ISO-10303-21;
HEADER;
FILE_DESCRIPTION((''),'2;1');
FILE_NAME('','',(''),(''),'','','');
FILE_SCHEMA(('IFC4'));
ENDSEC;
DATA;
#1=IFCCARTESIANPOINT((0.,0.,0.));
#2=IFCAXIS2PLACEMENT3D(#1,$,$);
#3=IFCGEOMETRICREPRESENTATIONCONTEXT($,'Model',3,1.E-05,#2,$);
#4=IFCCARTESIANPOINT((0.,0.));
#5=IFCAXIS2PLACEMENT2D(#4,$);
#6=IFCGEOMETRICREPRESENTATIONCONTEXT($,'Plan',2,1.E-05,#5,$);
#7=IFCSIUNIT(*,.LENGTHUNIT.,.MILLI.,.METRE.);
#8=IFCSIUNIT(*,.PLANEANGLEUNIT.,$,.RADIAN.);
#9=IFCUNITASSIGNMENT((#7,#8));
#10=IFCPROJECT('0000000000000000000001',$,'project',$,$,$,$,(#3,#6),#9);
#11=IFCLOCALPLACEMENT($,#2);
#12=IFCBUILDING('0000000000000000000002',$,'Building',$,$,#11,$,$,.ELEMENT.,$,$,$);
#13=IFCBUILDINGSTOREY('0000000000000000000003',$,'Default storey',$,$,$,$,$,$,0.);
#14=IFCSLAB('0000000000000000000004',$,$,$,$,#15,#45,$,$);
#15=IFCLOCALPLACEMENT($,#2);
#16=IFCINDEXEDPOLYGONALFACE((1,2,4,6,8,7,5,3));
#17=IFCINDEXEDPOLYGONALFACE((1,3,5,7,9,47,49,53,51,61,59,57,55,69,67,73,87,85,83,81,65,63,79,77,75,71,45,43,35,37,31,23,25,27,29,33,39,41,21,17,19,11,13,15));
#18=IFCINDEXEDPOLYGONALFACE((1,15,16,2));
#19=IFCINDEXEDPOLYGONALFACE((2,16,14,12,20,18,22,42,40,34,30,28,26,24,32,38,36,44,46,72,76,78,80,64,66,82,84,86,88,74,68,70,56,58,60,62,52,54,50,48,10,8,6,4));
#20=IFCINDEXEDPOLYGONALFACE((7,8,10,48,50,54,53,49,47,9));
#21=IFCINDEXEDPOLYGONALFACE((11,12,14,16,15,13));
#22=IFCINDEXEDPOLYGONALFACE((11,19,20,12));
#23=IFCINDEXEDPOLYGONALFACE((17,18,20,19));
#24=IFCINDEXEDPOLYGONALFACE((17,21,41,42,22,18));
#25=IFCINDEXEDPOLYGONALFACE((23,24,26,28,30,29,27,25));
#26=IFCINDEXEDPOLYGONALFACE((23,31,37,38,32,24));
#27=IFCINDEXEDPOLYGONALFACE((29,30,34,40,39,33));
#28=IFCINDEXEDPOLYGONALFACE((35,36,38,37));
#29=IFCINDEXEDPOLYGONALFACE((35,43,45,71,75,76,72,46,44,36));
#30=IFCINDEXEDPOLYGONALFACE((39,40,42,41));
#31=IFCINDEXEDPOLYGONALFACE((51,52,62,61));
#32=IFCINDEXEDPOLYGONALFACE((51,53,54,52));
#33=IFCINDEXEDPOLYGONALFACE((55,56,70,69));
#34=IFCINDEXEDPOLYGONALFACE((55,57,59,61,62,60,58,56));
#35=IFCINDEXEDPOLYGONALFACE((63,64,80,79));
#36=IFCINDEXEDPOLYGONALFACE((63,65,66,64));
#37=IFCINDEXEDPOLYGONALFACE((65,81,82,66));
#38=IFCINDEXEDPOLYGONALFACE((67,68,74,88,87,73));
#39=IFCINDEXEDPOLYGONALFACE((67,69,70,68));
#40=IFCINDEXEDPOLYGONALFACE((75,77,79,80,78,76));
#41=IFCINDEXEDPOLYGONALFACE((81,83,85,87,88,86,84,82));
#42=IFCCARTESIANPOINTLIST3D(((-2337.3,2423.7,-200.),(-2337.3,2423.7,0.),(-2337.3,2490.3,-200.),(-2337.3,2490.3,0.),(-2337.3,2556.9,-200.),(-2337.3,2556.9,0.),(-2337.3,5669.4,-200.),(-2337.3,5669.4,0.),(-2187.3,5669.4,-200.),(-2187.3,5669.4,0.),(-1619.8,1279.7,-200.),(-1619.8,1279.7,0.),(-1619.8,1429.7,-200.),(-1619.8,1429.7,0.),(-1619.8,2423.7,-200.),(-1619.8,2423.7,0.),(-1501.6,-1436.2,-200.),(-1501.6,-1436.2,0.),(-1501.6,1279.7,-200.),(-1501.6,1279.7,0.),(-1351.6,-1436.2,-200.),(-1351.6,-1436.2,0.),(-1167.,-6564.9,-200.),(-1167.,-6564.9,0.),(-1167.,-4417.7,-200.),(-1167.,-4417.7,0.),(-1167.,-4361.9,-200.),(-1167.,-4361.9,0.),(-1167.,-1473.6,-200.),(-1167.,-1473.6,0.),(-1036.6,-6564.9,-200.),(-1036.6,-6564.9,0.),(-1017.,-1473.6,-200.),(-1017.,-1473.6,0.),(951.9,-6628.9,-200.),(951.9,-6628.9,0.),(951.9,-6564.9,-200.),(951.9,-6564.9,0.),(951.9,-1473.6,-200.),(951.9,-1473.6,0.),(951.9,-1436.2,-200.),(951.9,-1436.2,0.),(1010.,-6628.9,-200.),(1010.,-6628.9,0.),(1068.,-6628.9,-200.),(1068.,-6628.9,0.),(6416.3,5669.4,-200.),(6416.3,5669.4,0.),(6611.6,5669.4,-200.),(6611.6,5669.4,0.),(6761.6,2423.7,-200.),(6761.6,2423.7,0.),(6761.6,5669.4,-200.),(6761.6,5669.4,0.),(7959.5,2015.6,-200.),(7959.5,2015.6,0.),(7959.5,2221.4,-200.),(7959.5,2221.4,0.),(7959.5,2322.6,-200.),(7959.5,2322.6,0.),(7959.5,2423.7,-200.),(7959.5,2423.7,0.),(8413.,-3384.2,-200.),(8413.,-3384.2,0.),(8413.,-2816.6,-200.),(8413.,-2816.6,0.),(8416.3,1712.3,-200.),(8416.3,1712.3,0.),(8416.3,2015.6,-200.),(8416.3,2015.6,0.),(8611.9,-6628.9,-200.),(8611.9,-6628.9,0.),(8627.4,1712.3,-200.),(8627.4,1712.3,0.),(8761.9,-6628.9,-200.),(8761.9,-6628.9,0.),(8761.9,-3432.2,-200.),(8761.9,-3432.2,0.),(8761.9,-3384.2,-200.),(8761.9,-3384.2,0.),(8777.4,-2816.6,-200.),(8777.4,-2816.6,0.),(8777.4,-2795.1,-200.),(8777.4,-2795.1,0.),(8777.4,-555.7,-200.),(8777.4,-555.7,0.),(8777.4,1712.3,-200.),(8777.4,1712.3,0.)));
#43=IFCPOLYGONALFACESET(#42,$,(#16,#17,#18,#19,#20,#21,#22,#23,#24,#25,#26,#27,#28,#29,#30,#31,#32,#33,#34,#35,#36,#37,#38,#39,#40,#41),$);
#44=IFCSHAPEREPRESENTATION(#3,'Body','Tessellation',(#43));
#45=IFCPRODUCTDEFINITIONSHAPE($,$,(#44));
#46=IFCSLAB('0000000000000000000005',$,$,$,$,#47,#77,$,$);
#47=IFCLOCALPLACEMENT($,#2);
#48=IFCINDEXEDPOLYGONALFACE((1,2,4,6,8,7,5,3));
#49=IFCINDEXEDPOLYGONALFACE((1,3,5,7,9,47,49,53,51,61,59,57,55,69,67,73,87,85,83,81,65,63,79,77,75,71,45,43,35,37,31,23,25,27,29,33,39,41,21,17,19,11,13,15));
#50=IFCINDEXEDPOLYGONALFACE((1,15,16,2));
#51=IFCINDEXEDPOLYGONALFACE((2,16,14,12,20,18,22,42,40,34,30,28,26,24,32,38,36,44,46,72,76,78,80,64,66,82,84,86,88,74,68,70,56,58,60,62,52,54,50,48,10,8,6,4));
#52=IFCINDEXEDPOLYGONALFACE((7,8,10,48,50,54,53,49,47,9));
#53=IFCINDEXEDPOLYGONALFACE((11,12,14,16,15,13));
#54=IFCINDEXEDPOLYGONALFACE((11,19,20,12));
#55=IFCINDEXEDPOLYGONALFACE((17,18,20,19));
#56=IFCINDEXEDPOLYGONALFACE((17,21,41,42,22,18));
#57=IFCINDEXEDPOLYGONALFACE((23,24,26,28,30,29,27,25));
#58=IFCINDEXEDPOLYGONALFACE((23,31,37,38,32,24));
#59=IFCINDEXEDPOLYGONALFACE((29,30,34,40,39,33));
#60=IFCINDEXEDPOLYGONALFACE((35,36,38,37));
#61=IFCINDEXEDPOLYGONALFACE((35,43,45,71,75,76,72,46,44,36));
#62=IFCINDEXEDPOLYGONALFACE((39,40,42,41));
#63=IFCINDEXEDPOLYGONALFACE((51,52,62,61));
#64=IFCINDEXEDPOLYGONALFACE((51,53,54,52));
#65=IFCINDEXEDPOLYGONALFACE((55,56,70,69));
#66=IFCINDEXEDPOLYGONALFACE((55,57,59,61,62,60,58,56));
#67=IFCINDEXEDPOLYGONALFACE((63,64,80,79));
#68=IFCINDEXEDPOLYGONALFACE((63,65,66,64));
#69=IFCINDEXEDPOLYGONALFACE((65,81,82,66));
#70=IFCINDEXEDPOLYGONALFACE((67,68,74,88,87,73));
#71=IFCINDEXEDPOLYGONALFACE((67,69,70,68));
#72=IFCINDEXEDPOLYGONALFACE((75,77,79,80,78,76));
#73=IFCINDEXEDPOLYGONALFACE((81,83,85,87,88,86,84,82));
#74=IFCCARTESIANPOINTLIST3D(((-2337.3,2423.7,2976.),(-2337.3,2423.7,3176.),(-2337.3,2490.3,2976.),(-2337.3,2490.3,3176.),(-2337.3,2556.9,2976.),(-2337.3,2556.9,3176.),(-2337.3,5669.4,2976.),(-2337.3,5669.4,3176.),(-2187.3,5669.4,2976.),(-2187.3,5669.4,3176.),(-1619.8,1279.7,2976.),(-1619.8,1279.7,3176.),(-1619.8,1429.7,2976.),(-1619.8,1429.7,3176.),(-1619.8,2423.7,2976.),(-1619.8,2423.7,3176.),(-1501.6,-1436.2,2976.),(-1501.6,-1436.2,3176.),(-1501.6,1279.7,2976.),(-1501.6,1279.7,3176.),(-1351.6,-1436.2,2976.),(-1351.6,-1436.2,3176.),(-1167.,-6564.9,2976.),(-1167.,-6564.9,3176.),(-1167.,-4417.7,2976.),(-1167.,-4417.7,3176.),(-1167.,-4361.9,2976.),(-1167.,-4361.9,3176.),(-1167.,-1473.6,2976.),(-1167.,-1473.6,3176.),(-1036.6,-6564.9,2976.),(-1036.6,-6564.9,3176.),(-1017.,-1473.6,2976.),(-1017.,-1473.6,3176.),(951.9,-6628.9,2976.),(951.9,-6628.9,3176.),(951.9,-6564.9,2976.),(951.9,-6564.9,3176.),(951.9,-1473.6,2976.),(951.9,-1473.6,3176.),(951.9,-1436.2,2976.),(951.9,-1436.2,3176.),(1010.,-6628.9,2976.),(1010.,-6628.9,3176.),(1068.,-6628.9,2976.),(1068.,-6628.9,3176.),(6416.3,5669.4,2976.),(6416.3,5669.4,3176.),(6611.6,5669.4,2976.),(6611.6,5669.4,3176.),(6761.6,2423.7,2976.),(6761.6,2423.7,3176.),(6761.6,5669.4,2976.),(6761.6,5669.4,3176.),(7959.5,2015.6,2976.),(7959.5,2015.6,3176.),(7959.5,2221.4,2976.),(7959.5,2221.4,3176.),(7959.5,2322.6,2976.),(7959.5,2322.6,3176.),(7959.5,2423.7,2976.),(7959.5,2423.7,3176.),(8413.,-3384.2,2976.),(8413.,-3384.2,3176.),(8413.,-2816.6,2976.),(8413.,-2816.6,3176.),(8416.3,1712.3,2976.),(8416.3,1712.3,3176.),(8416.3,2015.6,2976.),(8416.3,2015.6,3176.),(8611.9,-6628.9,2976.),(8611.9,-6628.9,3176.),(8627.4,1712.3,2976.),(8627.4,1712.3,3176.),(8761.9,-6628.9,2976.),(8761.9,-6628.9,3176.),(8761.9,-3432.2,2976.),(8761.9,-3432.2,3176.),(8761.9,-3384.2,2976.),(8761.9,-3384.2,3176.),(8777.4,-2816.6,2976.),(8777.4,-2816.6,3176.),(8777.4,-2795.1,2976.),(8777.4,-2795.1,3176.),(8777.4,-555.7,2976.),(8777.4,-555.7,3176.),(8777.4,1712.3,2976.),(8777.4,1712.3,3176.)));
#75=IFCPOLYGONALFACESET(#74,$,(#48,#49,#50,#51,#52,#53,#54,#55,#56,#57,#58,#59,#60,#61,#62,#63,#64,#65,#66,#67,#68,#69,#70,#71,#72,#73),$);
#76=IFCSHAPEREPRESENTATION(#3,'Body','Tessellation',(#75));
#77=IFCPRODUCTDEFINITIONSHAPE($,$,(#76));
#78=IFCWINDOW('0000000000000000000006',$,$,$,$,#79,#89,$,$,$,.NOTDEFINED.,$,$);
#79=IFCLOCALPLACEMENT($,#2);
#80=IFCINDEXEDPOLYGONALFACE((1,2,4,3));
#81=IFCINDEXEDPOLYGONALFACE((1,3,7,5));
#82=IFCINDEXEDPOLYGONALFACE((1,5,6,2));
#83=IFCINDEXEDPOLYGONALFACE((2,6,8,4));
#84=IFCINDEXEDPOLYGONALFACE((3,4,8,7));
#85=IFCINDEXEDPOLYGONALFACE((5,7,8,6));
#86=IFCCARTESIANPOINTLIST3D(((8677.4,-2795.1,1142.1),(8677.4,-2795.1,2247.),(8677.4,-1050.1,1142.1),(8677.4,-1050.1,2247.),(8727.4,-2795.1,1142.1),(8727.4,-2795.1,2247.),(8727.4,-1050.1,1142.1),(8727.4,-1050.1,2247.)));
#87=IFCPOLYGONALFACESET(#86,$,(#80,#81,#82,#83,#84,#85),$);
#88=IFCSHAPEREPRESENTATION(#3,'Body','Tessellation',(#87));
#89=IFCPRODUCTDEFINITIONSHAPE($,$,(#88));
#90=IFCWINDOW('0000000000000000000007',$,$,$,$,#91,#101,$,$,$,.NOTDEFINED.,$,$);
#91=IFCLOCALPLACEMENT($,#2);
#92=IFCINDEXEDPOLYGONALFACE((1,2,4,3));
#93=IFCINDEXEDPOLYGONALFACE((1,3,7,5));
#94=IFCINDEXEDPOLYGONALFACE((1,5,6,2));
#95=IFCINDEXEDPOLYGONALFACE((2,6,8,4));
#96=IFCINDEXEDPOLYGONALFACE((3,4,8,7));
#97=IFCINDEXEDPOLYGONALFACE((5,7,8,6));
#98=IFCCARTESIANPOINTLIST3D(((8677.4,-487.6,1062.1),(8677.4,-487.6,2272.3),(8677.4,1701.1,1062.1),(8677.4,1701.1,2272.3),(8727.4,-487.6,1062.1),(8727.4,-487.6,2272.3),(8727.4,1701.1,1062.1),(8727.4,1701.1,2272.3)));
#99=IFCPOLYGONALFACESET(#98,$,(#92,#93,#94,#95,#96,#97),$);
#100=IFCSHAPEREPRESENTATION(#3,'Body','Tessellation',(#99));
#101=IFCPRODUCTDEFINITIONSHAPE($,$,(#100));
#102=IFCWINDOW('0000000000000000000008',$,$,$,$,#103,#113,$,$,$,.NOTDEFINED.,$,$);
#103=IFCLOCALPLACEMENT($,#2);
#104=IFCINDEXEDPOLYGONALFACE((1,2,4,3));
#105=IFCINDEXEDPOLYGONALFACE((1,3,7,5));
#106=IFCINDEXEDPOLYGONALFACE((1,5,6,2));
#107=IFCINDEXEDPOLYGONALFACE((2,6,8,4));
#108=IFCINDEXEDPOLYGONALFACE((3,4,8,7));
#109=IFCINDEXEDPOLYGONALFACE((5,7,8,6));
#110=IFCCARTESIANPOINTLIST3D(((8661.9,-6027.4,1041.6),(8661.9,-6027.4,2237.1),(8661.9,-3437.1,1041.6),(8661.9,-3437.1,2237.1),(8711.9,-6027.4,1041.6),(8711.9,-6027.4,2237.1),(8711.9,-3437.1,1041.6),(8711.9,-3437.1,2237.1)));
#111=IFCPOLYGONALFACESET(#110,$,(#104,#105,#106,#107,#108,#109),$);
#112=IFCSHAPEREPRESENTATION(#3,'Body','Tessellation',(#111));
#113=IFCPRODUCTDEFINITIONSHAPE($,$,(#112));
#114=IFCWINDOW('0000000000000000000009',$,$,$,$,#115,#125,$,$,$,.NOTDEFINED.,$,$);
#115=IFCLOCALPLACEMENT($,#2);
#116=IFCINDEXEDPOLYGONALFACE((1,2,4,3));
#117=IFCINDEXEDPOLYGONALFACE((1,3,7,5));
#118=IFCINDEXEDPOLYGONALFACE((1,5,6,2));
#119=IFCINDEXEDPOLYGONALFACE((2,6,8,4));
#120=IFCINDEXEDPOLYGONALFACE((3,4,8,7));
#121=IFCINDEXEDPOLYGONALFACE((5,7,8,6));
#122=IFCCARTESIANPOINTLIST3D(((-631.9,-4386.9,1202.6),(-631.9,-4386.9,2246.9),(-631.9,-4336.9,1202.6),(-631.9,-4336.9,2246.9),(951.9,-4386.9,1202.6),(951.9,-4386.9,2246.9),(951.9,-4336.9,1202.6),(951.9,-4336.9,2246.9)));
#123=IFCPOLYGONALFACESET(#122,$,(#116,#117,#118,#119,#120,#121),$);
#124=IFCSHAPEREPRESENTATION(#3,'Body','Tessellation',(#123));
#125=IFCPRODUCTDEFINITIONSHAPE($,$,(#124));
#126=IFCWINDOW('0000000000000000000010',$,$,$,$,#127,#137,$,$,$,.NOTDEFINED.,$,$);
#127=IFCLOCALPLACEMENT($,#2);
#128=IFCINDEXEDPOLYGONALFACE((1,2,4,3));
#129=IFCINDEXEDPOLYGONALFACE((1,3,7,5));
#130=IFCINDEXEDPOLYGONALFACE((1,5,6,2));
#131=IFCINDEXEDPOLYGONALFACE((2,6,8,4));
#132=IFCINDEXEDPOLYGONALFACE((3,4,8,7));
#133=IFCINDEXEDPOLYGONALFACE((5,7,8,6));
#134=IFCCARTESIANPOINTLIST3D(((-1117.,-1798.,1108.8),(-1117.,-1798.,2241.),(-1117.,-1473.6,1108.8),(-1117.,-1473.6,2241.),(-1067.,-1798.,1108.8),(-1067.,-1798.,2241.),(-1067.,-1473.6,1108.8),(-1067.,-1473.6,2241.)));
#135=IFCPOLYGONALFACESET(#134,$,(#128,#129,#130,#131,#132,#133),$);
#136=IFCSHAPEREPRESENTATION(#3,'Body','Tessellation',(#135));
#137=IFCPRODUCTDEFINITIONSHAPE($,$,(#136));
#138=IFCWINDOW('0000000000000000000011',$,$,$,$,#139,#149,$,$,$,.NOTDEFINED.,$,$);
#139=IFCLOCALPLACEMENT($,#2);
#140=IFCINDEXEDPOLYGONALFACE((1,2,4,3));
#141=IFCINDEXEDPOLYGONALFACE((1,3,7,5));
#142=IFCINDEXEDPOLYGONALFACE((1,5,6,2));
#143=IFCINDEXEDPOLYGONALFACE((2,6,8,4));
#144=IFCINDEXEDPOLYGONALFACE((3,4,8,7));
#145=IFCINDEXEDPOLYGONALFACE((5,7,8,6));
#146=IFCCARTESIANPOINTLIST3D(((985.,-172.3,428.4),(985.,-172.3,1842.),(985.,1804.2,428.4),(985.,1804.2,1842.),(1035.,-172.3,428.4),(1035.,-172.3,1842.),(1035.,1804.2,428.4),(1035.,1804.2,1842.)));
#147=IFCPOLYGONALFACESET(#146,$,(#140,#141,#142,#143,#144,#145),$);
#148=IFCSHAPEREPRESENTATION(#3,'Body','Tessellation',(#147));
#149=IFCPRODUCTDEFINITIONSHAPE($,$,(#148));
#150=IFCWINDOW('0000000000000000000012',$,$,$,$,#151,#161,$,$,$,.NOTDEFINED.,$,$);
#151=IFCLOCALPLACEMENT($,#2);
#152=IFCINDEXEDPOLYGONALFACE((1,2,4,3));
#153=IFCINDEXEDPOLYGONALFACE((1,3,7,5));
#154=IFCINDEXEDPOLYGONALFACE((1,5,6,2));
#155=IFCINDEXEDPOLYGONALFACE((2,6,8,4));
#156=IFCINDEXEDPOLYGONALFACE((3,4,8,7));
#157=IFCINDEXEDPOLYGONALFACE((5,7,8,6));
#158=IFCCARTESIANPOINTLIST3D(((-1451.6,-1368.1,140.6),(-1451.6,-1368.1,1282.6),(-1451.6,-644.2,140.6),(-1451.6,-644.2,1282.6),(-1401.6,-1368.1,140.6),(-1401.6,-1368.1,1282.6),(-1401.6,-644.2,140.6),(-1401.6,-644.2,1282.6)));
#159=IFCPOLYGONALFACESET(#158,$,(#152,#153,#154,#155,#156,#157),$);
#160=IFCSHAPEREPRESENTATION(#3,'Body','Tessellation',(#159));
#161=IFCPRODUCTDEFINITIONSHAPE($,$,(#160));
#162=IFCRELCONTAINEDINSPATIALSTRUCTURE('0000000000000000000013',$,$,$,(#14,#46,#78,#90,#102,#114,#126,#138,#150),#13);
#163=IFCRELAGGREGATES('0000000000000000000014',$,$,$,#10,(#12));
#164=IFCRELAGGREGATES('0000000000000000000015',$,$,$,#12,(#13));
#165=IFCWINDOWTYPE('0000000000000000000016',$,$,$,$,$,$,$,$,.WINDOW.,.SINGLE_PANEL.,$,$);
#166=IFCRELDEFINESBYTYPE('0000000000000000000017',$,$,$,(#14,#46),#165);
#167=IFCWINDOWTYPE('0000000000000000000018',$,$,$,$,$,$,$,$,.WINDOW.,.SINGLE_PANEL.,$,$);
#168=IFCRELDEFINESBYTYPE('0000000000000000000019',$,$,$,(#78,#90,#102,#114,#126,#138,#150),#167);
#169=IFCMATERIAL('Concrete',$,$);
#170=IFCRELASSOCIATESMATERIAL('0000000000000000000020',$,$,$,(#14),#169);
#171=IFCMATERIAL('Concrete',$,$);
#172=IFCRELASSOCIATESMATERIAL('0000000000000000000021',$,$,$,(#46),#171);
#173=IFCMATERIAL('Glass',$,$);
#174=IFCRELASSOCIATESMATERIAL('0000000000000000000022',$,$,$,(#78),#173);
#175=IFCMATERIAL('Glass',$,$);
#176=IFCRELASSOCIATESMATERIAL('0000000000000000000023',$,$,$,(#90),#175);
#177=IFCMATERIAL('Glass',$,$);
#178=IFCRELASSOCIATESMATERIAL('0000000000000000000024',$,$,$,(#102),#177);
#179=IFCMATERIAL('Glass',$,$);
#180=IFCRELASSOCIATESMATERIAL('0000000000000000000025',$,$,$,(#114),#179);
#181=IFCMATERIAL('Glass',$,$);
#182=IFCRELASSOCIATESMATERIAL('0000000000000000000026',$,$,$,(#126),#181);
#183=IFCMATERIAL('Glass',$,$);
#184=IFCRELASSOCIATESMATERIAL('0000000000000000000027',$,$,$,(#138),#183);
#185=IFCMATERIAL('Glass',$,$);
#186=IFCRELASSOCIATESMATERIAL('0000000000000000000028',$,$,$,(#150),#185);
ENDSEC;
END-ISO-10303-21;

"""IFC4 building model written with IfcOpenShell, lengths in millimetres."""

from ifc_helpers import new_model, si_unit, frame, origin, origin_2d, place, context, project, spatial, polyline, rectangle, outline, extrude, material, type_object, element, save


model = new_model("IFC4")

# Units and contexts
model_context = context("Model", 3, precision=1e-05, world=origin())
plan_context = context("Plan", 2, precision=1e-05, world=origin_2d())
ifc_project = project(units=[si_unit("LENGTHUNIT", "METRE", prefix="MILLI"), si_unit("PLANEANGLEUNIT", "RADIAN")], contexts=[model_context, plan_context])

# Building, storey
placement = place(None, origin())
building = spatial("IfcBuilding", under=ifc_project, at=placement, Name="Building", CompositionType="ELEMENT")
storey = spatial("IfcBuildingStorey", under=building, Name="Default storey", Elevation=0.0)

# Slabs
ifc_material_1 = material(Name="Concrete")
window_type_1 = type_object("IfcWindowType", PartitioningType="SINGLE_PANEL", PredefinedType="WINDOW")
element("IfcSlab", 1, at=placement, inside=storey, type_object=window_type_1, material=ifc_material_1, context=model_context, shape_type="SweptSolid", body=[
    extrude(outline(polyline([(8627.4, 1712.3), (8416.3, 1712.3), (8416.3, 2015.6), (7959.5, 2015.6), (7959.5, 2221.4), (7959.5, 2322.6), (7959.5, 2423.7), (6761.6, 2423.7), (6761.6, 5669.4), (6611.6, 5669.4), (6416.3, 5669.4), (-2187.3, 5669.4), (-2337.3, 5669.4), (-2337.3, 2556.9), (-2337.3, 2490.3), (-2337.3, 2423.7), (-1619.8, 2423.7), (-1619.8, 1429.7), (-1619.8, 1279.7), (-1501.6, 1279.7), (-1501.6, -1436.2), (-1351.6, -1436.2), (951.9, -1436.2), (951.9, -1473.6), (-1017.0, -1473.6), (-1167.0, -1473.6), (-1167.0, -4361.9), (-1167.0, -4417.7), (-1167.0, -6564.9), (-1036.6, -6564.9), (951.9, -6564.9), (951.9, -6628.9), (1010.0, -6628.9), (1068.0, -6628.9), (8611.9, -6628.9), (8761.9, -6628.9), (8761.9, -3432.2), (8761.9, -3384.2), (8413.0, -3384.2), (8413.0, -2816.6), (8777.4, -2816.6), (8777.4, -2795.1), (8777.4, -555.7), (8777.4, 1712.3), (8627.4, 1712.3)])), frame((0.0, 0.0, -200.0), z_axis=(0.0, 0.0, 1000.0), x_axis=(1000.0, 0.0, 0.0)), (0.0, 0.0, 1.0), 200.0),
])
ifc_material_2 = material(Name="Concrete")
element("IfcSlab", 2, at=placement, inside=storey, type_object=window_type_1, material=ifc_material_2, context=model_context, shape_type="SweptSolid", body=[
    extrude(outline(polyline([(8627.4, 1712.3), (8416.3, 1712.3), (8416.3, 2015.6), (7959.5, 2015.6), (7959.5, 2221.4), (7959.5, 2322.6), (7959.5, 2423.7), (6761.6, 2423.7), (6761.6, 5669.4), (6611.6, 5669.4), (6416.3, 5669.4), (-2187.3, 5669.4), (-2337.3, 5669.4), (-2337.3, 2556.9), (-2337.3, 2490.3), (-2337.3, 2423.7), (-1619.8, 2423.7), (-1619.8, 1429.7), (-1619.8, 1279.7), (-1501.6, 1279.7), (-1501.6, -1436.2), (-1351.6, -1436.2), (951.9, -1436.2), (951.9, -1473.6), (-1017.0, -1473.6), (-1167.0, -1473.6), (-1167.0, -4361.9), (-1167.0, -4417.7), (-1167.0, -6564.9), (-1036.6, -6564.9), (951.9, -6564.9), (951.9, -6628.9), (1010.0, -6628.9), (1068.0, -6628.9), (8611.9, -6628.9), (8761.9, -6628.9), (8761.9, -3432.2), (8761.9, -3384.2), (8413.0, -3384.2), (8413.0, -2816.6), (8777.4, -2816.6), (8777.4, -2795.1), (8777.4, -555.7), (8777.4, 1712.3), (8627.4, 1712.3)])), frame((0.0, 0.0, 2976.0), z_axis=(0.0, 0.0, 1000.0), x_axis=(1000.0, 0.0, 0.0)), (0.0, 0.0, 1.0), 200.0),
])

# Windows
ifc_material_3 = material(Name="Glass")
window_type_2 = type_object("IfcWindowType", PartitioningType="SINGLE_PANEL", PredefinedType="WINDOW")
element("IfcWindow", 3, at=placement, inside=storey, type_object=window_type_2, material=ifc_material_3, PredefinedType="NOTDEFINED", context=model_context, shape_type="CSG", body=[
    extrude(rectangle(XDim=1745.1, YDim=50.0, at=origin_2d()), frame((8702.4, -1922.6, 1142.1), z_axis=(0.0, 0.0, 1000.0), x_axis=(0.0, 1745.059967, 0.0)), (0.0, 0.0, 1.0), 1105.0),
])
ifc_material_4 = material(Name="Glass")
element("IfcWindow", 4, at=placement, inside=storey, type_object=window_type_2, material=ifc_material_4, PredefinedType="NOTDEFINED", context=model_context, shape_type="CSG", body=[
    extrude(rectangle(XDim=2188.7, YDim=50.0, at=origin_2d()), frame((8702.4, 606.8, 1062.1), z_axis=(0.0, 0.0, 1000.0), x_axis=(0.0, 2188.736022, 0.0)), (0.0, 0.0, 1.0), 1210.2),
])
ifc_material_5 = material(Name="Glass")
element("IfcWindow", 5, at=placement, inside=storey, type_object=window_type_2, material=ifc_material_5, PredefinedType="NOTDEFINED", context=model_context, shape_type="CSG", body=[
    extrude(rectangle(XDim=2590.4, YDim=50.0, at=origin_2d()), frame((8686.9, -4732.3, 1041.6), z_axis=(0.0, 0.0, 1000.0), x_axis=(0.0, 2590.360165, 0.0)), (0.0, 0.0, 1.0), 1195.5),
])
ifc_material_6 = material(Name="Glass")
element("IfcWindow", 6, at=placement, inside=storey, type_object=window_type_2, material=ifc_material_6, PredefinedType="NOTDEFINED", context=model_context, shape_type="CSG", body=[
    extrude(rectangle(XDim=1583.9, YDim=50.0, at=origin_2d()), frame((160.0, -4361.9, 1202.6), z_axis=(0.0, 0.0, 1000.0), x_axis=(1583.856672, 0.0, 0.0)), (0.0, 0.0, 1.0), 1044.3),
])
ifc_material_7 = material(Name="Glass")
element("IfcWindow", 7, at=placement, inside=storey, type_object=window_type_2, material=ifc_material_7, PredefinedType="NOTDEFINED", context=model_context, shape_type="CSG", body=[
    extrude(rectangle(XDim=324.5, YDim=50.0, at=origin_2d()), frame((-1092.0, -1635.8, 1108.8), z_axis=(0.0, 0.0, 1000.0), x_axis=(0.0, 324.46003, 0.0)), (0.0, 0.0, 1.0), 1132.2),
])
ifc_material_8 = material(Name="Glass")
element("IfcWindow", 8, at=placement, inside=storey, type_object=window_type_2, material=ifc_material_8, PredefinedType="NOTDEFINED", context=model_context, shape_type="CSG", body=[
    extrude(rectangle(XDim=1976.5, YDim=50.0, at=origin_2d()), frame((1010.0, 816.0, 428.4), z_axis=(0.0, 0.0, 1000.0), x_axis=(0.0, 1976.492986, 0.0)), (0.0, 0.0, 1.0), 1413.6),
])
ifc_material_9 = material(Name="Glass")
element("IfcWindow", 9, at=placement, inside=storey, type_object=window_type_2, material=ifc_material_9, PredefinedType="NOTDEFINED", context=model_context, shape_type="CSG", body=[
    extrude(rectangle(XDim=723.9, YDim=50.0, at=origin_2d()), frame((-1426.6, -1006.1, 140.6), z_axis=(0.0, 0.0, 1000.0), x_axis=(0.0, 723.859012, 0.0)), (0.0, 0.0, 1.0), 1142.0),
])

save(model, "model.ifc")
